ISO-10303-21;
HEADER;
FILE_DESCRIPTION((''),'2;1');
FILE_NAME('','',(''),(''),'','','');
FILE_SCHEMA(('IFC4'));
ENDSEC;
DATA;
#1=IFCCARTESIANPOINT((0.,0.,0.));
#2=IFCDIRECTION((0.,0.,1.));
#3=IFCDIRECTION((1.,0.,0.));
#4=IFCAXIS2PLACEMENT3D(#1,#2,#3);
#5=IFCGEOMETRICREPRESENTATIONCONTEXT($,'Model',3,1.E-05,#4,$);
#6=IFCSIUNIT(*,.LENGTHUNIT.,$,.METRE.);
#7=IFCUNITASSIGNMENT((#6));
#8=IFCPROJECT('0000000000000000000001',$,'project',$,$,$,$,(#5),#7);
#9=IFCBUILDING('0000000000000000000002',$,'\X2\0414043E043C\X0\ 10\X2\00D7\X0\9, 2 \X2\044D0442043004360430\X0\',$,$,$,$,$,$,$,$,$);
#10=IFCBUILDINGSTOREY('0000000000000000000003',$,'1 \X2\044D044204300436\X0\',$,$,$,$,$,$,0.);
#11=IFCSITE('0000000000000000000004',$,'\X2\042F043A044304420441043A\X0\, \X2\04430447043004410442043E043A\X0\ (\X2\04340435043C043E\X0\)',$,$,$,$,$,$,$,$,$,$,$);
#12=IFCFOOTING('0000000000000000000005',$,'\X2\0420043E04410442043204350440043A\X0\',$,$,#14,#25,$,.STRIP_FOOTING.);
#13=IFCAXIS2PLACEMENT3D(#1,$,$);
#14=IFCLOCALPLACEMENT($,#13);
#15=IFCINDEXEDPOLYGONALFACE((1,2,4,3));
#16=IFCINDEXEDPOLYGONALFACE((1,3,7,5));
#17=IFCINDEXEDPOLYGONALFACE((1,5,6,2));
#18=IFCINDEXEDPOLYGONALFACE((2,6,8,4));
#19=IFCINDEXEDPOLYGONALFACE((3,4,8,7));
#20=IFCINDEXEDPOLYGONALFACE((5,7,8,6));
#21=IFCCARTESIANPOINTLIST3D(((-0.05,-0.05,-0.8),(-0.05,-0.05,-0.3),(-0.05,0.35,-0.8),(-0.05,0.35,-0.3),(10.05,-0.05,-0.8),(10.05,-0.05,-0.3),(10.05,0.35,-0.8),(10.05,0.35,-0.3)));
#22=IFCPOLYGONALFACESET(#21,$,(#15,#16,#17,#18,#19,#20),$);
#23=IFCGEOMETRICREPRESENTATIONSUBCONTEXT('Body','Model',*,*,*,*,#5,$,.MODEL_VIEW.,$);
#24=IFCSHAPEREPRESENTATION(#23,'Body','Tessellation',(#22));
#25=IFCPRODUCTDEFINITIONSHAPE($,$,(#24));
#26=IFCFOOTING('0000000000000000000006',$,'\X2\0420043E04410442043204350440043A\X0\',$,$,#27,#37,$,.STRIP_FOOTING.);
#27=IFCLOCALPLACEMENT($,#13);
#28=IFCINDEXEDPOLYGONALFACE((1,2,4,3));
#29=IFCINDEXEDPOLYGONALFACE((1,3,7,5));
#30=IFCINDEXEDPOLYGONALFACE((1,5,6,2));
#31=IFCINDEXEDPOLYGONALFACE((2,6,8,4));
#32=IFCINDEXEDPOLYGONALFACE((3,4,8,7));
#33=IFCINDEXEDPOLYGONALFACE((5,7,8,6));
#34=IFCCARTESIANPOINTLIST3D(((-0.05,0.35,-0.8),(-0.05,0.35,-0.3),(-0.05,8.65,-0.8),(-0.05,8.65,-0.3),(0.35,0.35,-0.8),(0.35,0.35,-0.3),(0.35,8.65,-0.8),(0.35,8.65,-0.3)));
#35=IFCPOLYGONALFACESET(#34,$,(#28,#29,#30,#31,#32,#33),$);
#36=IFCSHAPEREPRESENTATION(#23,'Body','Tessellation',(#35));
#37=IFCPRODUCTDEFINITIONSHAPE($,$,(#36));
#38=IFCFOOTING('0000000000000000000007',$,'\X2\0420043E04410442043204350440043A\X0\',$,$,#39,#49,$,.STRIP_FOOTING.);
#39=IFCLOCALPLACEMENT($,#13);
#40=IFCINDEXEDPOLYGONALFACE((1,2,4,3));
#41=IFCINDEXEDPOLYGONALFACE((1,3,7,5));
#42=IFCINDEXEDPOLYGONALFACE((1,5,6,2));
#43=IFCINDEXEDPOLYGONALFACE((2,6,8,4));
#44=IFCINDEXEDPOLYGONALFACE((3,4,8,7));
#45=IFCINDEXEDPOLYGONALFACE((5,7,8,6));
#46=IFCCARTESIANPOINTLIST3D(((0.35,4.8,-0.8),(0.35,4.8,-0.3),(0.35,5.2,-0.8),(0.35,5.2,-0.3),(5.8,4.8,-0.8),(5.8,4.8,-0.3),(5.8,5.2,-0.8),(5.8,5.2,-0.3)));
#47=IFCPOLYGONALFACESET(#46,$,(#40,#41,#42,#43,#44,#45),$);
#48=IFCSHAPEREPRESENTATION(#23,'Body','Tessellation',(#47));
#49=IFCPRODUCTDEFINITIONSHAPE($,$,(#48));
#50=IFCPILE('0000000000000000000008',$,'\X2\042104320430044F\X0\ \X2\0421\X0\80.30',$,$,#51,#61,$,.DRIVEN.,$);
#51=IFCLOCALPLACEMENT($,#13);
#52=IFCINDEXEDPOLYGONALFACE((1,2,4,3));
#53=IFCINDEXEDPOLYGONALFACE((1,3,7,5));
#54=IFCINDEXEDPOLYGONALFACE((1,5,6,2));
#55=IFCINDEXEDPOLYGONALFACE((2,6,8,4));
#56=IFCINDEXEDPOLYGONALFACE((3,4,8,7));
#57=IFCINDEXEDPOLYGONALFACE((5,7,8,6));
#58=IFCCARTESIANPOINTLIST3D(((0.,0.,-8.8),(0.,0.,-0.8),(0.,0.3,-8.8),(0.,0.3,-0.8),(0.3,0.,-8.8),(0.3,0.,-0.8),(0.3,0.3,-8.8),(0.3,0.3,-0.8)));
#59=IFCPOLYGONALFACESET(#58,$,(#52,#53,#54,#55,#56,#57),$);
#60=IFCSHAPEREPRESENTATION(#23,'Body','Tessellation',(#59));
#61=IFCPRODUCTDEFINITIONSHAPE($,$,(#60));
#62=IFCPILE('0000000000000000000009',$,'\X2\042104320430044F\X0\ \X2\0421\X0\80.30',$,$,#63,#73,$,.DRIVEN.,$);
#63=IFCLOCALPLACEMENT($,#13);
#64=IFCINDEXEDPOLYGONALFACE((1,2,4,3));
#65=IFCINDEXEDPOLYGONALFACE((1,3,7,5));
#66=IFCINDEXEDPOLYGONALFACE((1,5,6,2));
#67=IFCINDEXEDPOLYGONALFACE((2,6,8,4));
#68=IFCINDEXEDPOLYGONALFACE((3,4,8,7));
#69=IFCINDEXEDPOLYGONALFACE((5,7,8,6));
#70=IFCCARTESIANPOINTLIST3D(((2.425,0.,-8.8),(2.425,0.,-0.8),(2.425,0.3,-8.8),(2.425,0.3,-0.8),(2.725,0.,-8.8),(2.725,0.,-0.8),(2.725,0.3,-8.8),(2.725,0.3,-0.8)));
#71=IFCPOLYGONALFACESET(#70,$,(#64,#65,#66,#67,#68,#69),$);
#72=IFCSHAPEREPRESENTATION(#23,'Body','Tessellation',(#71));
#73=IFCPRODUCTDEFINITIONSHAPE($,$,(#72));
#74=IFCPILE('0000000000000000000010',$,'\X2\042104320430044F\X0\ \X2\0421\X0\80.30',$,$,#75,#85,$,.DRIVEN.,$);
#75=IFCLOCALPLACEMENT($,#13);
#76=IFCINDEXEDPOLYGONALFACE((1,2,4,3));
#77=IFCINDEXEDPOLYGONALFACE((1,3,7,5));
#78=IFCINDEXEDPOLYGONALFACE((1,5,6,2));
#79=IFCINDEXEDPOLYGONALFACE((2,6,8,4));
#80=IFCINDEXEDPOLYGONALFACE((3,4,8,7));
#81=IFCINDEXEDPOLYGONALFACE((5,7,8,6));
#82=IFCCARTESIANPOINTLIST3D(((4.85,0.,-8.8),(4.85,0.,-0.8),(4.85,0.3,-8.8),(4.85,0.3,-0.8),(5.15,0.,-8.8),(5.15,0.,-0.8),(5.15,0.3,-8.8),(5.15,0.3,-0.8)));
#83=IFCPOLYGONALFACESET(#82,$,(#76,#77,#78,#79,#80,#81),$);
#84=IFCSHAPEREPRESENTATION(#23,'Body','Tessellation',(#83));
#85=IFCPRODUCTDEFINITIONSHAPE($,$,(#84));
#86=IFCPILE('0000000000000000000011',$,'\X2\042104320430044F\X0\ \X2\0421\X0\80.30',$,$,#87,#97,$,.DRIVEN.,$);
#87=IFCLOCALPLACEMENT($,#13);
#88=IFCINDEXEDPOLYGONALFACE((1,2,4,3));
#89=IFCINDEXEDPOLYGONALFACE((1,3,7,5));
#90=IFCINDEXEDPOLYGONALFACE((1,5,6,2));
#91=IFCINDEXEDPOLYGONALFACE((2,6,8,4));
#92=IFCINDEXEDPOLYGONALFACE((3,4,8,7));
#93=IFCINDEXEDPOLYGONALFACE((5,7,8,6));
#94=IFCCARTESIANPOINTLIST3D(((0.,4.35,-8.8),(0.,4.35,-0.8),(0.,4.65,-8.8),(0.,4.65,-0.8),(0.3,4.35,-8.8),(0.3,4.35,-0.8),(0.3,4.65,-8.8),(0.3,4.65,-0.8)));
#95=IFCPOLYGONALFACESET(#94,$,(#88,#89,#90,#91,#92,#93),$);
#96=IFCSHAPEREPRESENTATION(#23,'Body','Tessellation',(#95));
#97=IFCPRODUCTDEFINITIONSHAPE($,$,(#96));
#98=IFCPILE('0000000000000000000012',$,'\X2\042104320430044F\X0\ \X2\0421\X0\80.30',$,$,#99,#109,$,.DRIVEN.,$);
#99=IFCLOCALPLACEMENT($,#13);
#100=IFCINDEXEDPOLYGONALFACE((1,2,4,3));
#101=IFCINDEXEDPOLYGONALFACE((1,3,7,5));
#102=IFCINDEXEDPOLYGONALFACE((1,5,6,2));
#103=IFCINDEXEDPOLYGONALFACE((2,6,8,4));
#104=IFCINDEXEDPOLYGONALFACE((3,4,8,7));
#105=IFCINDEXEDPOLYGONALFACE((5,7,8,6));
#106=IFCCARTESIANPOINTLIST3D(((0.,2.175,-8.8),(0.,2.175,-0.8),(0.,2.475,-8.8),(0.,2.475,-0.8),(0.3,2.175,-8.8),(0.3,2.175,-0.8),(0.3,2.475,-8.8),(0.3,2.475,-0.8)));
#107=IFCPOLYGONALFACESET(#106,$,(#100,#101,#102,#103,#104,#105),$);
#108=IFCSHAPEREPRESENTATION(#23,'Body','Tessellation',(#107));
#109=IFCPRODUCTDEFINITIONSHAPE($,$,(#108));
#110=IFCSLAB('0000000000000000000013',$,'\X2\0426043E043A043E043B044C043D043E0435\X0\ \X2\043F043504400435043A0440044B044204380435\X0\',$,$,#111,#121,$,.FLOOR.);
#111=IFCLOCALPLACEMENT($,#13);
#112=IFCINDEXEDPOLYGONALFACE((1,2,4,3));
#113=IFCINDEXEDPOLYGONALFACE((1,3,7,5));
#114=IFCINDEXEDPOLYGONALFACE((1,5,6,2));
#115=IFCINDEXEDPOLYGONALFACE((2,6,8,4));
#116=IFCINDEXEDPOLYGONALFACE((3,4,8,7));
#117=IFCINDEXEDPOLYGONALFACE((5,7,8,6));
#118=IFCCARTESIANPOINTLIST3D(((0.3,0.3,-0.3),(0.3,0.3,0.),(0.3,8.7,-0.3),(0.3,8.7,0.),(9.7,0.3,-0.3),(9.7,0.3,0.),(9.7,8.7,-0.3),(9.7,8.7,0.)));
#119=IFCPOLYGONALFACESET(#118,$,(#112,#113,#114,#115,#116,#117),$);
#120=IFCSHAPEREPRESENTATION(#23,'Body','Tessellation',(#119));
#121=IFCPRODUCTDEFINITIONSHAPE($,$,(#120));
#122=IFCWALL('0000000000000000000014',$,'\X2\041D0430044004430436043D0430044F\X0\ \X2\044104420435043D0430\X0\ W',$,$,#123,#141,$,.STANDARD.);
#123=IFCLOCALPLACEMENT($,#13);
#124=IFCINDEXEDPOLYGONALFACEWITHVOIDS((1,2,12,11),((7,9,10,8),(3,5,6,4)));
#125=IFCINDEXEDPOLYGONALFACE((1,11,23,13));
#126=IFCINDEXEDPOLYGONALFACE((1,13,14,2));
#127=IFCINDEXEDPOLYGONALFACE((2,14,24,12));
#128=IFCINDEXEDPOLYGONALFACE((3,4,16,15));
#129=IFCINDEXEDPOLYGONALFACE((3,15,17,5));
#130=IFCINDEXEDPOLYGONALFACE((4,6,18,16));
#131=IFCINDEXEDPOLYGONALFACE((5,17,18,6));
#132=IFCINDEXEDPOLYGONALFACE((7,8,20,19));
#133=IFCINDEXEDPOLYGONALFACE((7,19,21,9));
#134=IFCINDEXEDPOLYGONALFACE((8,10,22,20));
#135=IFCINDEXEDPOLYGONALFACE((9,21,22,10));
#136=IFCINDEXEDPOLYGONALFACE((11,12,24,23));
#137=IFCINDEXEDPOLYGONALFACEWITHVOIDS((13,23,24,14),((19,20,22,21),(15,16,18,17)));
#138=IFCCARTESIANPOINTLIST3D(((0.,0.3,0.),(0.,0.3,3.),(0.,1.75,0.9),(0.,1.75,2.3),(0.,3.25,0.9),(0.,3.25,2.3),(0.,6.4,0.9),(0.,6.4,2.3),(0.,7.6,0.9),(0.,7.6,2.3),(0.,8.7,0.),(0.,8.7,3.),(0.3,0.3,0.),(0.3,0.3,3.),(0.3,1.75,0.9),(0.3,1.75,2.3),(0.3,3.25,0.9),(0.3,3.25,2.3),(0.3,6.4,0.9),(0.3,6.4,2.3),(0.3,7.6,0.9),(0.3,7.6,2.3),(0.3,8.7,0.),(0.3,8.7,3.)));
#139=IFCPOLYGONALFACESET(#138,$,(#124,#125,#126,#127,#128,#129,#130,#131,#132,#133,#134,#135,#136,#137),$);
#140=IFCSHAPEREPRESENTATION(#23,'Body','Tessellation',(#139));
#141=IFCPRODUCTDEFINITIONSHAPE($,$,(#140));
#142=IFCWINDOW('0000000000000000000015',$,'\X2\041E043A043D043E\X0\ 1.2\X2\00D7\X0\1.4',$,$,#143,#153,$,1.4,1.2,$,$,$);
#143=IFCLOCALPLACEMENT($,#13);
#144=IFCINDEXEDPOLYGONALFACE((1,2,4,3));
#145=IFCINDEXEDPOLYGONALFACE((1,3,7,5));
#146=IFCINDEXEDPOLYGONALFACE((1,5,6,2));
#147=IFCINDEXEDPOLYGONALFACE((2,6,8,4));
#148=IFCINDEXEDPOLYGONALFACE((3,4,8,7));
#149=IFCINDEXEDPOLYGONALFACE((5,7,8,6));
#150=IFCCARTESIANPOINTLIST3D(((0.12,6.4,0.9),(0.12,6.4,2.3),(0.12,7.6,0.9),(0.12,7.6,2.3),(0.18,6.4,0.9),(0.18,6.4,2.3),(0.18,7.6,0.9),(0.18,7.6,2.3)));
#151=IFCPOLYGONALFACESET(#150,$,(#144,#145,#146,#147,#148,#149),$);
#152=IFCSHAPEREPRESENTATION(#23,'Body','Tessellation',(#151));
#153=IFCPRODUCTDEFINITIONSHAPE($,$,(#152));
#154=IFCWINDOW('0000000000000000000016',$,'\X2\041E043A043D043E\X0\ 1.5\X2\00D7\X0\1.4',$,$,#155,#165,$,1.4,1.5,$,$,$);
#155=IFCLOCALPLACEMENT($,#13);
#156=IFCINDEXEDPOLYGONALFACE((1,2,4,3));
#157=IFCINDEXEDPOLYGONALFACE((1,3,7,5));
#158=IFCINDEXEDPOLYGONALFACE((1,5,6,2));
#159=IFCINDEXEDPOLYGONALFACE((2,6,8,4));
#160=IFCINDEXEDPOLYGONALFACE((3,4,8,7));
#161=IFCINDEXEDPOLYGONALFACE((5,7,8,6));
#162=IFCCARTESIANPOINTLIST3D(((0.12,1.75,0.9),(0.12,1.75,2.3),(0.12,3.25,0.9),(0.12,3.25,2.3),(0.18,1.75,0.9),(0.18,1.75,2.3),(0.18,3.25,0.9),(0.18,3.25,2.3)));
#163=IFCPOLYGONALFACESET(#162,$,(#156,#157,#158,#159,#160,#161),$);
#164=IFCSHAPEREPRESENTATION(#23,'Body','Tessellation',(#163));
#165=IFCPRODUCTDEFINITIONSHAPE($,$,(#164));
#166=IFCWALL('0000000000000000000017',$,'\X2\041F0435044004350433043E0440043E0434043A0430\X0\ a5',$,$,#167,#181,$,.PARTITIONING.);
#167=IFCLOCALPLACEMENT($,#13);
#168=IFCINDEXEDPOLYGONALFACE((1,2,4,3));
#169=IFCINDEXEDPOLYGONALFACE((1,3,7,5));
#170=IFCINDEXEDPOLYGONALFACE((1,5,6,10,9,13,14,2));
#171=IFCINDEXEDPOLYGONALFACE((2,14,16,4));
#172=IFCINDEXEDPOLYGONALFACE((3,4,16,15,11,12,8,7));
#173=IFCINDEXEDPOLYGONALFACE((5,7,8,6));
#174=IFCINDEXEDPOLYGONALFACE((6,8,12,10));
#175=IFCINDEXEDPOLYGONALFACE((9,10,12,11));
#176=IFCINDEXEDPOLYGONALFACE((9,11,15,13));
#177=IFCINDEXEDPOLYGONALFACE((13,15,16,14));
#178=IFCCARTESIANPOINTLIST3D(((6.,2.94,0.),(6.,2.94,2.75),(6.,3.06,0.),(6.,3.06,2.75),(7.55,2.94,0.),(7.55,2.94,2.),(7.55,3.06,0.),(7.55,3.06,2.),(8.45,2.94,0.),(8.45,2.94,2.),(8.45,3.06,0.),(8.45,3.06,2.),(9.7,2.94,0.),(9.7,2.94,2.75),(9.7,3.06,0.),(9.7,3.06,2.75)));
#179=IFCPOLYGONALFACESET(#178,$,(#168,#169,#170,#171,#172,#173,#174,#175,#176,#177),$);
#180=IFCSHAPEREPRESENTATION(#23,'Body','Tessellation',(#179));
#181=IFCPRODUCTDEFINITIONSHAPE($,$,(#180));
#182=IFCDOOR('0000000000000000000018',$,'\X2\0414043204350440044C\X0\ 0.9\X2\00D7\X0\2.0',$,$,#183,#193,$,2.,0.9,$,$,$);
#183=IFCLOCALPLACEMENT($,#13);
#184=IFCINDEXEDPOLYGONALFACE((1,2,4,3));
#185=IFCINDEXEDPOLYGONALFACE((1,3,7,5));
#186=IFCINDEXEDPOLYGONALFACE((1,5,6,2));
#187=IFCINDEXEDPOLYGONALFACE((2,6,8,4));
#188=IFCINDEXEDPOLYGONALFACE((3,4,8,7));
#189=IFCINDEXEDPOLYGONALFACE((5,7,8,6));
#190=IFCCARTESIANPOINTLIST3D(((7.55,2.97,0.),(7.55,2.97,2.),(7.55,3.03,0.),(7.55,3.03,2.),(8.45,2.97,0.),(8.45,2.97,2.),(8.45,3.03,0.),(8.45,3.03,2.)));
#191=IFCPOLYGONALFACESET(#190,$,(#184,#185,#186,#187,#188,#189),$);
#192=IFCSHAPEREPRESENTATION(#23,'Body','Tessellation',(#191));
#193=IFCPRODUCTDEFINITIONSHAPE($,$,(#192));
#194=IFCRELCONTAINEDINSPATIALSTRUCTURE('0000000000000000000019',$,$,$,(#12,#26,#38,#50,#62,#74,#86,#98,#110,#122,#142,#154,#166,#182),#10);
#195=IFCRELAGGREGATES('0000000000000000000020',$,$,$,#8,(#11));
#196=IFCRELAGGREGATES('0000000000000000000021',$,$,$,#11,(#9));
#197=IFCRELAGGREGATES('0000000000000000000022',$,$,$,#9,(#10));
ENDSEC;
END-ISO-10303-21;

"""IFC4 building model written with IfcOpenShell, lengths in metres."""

from ifc_helpers import new_model, si_unit, frame, origin_with_axes, place, context, subcontext, project, spatial, indexed_curve, rectangle, outline, extrude, element, fill, save


model = new_model("IFC4")

# Units and contexts
model_context = context("Model", 3, precision=1e-05, world=origin_with_axes())
body_context = subcontext(model_context, "Body", "Model", "MODEL_VIEW")
ifc_project = project(units=[si_unit("LENGTHUNIT", "METRE")], contexts=[model_context])

# Site, building, storey
site = spatial("IfcSite", under=ifc_project, Name="Якутск, участок (демо)")
building = spatial("IfcBuilding", under=site, Name="Дом 10×9, 2 этажа")
storey = spatial("IfcBuildingStorey", under=building, Name="1 этаж", Elevation=0.0)

# Footings
footing_1_placement = place(None, frame((-0.05, -0.05, -0.8), z_axis=(0.0, 0.0, 1.0), x_axis=(1.0, 0.0, 0.0)))
element("IfcFooting", 1, at=footing_1_placement, inside=storey, Name="Ростверк", PredefinedType="STRIP_FOOTING", context=body_context, shape_type="SweptSolid", body=[
    extrude(outline(indexed_curve([(0.0, 0.0), (0.0, 0.4), (10.1, 0.4), (10.1, 0.0), (0.0, 0.0)], self_intersect=False)), origin_with_axes(), (0.0, 0.0, 1.0), 0.5),
])
footing_2_placement = place(None, frame((0.35, 0.35, -0.8), z_axis=(0.0, 0.0, 1.0), x_axis=(0.0, 1.0, 0.0)))
element("IfcFooting", 2, at=footing_2_placement, inside=storey, Name="Ростверк", PredefinedType="STRIP_FOOTING", context=body_context, shape_type="SweptSolid", body=[
    extrude(outline(indexed_curve([(0.0, 0.0), (0.0, 0.4), (8.3, 0.4), (8.3, 0.0), (0.0, 0.0)], self_intersect=False)), origin_with_axes(), (0.0, 0.0, 1.0), 0.5),
])
footing_3_placement = place(None, frame((0.35, 4.8, -0.8), z_axis=(0.0, 0.0, 1.0), x_axis=(1.0, 0.0, 0.0)))
element("IfcFooting", 3, at=footing_3_placement, inside=storey, Name="Ростверк", PredefinedType="STRIP_FOOTING", context=body_context, shape_type="SweptSolid", body=[
    extrude(outline(indexed_curve([(0.0, 0.0), (0.0, 0.4), (5.45, 0.4), (5.45, 0.0), (0.0, 0.0)], self_intersect=False)), origin_with_axes(), (0.0, 0.0, 1.0), 0.5),
])

# Piles
for number, where, z_axis, x_axis, name in (
    (4, (0.15, 0.15, -8.8), (0.0, 0.0, 1.0), (1.0, 0.0, 0.0), "Свая С80.30"),
    (5, (2.575, 0.15, -8.8), (0.0, 0.0, 1.0), (1.0, 0.0, 0.0), "Свая С80.30"),
    (6, (5.0, 0.15, -8.8), (0.0, 0.0, 1.0), (1.0, 0.0, 0.0), "Свая С80.30"),
    (7, (0.15, 4.5, -8.8), (0.0, 0.0, 1.0), (1.0, 0.0, 0.0), "Свая С80.30"),
    (8, (0.15, 2.325, -8.8), (0.0, 0.0, 1.0), (1.0, 0.0, 0.0), "Свая С80.30"),
):
    element("IfcPile", number, at=place(None, frame(where, z_axis=z_axis, x_axis=x_axis)), inside=storey, Name=name, PredefinedType="DRIVEN", context=body_context, shape_type="SweptSolid", body=[
        extrude(rectangle(XDim=0.3, YDim=0.3), origin_with_axes(), (0.0, 0.0, 1.0), 8.0),
    ])

# Slab
slab_placement = place(None, frame((0.0, 0.0, -0.3), z_axis=(0.0, 0.0, 1.0), x_axis=(1.0, 0.0, 0.0)))
element("IfcSlab", 9, at=slab_placement, inside=storey, Name="Цокольное перекрытие", PredefinedType="FLOOR", context=body_context, shape_type="SweptSolid", body=[
    extrude(outline(indexed_curve([(0.3, 0.3), (9.7, 0.3), (9.7, 8.7), (0.3, 8.7)])), None, (0.0, 0.0, 1.0), 0.3),
])

# Wall, openings, windows
wall_1_placement = place(None, frame((0.3, 0.3, 0.0), z_axis=(0.0, 0.0, 1.0), x_axis=(0.0, 1.0, 0.0)))
wall_1 = element("IfcWall", 10, at=wall_1_placement, inside=storey, Name="Наружная стена W", PredefinedType="STANDARD", context=body_context, shape_type="SweptSolid", body=[
    extrude(outline(indexed_curve([(0.0, 0.0), (0.0, 0.3), (8.4, 0.3), (8.4, 0.0), (0.0, 0.0)], self_intersect=False)), origin_with_axes(), (0.0, 0.0, 1.0), 3.0),
])
opening_1_placement = place(wall_1_placement, frame((6.1, -0.05, 0.9), z_axis=(0.0, 0.0, 1.0), x_axis=(1.0, 0.0, 0.0)))
opening_1 = element("IfcOpeningElement", 11, at=opening_1_placement, cuts=wall_1, context=body_context, shape_type="SweptSolid", body=[
    extrude(outline(indexed_curve([(0.0, 0.0), (0.0, 0.4), (1.2, 0.4), (1.2, 0.0), (0.0, 0.0)], self_intersect=False)), origin_with_axes(), (0.0, 0.0, 1.0), 1.4),
])
opening_2_placement = place(wall_1_placement, frame((1.45, -0.05, 0.9), z_axis=(0.0, 0.0, 1.0), x_axis=(1.0, 0.0, 0.0)))
opening_2 = element("IfcOpeningElement", 12, at=opening_2_placement, cuts=wall_1, context=body_context, shape_type="SweptSolid", body=[
    extrude(outline(indexed_curve([(0.0, 0.0), (0.0, 0.4), (1.5, 0.4), (1.5, 0.0), (0.0, 0.0)], self_intersect=False)), origin_with_axes(), (0.0, 0.0, 1.0), 1.4),
])
window_1_placement = place(opening_1_placement, frame((0.0, 0.17, 0.0), z_axis=(0.0, 0.0, 1.0), x_axis=(1.0, 0.0, 0.0)))
window_1 = element("IfcWindow", 13, at=window_1_placement, inside=storey, Name="Окно 1.2×1.4", OverallHeight=1.4, OverallWidth=1.2, context=body_context, shape_type="SweptSolid", body=[
    extrude(outline(indexed_curve([(0.0, 0.0), (0.0, 0.06), (1.2, 0.06), (1.2, 0.0), (0.0, 0.0)], self_intersect=False)), origin_with_axes(), (0.0, 0.0, 1.0), 1.4),
])
fill(opening_1, window_1)
window_2_placement = place(opening_2_placement, frame((0.0, 0.17, 0.0), z_axis=(0.0, 0.0, 1.0), x_axis=(1.0, 0.0, 0.0)))
window_2 = element("IfcWindow", 14, at=window_2_placement, inside=storey, Name="Окно 1.5×1.4", OverallHeight=1.4, OverallWidth=1.5, context=body_context, shape_type="SweptSolid", body=[
    extrude(outline(indexed_curve([(0.0, 0.0), (0.0, 0.06), (1.5, 0.06), (1.5, 0.0), (0.0, 0.0)], self_intersect=False)), origin_with_axes(), (0.0, 0.0, 1.0), 1.4),
])
fill(opening_2, window_2)

# Wall, opening, door
wall_2_placement = place(None, frame((6.0, 2.94, 0.0), z_axis=(0.0, 0.0, 1.0), x_axis=(1.0, 0.0, 0.0)))
wall_2 = element("IfcWall", 15, at=wall_2_placement, inside=storey, Name="Перегородка a5", PredefinedType="PARTITIONING", context=body_context, shape_type="SweptSolid", body=[
    extrude(outline(indexed_curve([(0.0, 0.0), (0.0, 0.12), (3.7, 0.12), (3.7, 0.0), (0.0, 0.0)], self_intersect=False)), origin_with_axes(), (0.0, 0.0, 1.0), 2.75),
])
opening_3_placement = place(wall_2_placement, frame((1.55, -0.05, 0.0), z_axis=(0.0, 0.0, 1.0), x_axis=(1.0, 0.0, 0.0)))
opening_3 = element("IfcOpeningElement", 16, at=opening_3_placement, cuts=wall_2, context=body_context, shape_type="SweptSolid", body=[
    extrude(outline(indexed_curve([(0.0, 0.0), (0.0, 0.22), (0.9, 0.22), (0.9, 0.0), (0.0, 0.0)], self_intersect=False)), origin_with_axes(), (0.0, 0.0, 1.0), 2.0),
])
door_1_placement = place(opening_3_placement, frame((0.0, 0.08, 0.0), z_axis=(0.0, 0.0, 1.0), x_axis=(1.0, 0.0, 0.0)))
door_1 = element("IfcDoor", 17, at=door_1_placement, inside=storey, Name="Дверь 0.9×2.0", OverallHeight=2.0, OverallWidth=0.9, context=body_context, shape_type="SweptSolid", body=[
    extrude(outline(indexed_curve([(0.0, 0.0), (0.0, 0.06), (0.9, 0.06), (0.9, 0.0), (0.0, 0.0)], self_intersect=False)), origin_with_axes(), (0.0, 0.0, 1.0), 2.0),
])
fill(opening_3, door_1)

save(model, "model.ifc")
